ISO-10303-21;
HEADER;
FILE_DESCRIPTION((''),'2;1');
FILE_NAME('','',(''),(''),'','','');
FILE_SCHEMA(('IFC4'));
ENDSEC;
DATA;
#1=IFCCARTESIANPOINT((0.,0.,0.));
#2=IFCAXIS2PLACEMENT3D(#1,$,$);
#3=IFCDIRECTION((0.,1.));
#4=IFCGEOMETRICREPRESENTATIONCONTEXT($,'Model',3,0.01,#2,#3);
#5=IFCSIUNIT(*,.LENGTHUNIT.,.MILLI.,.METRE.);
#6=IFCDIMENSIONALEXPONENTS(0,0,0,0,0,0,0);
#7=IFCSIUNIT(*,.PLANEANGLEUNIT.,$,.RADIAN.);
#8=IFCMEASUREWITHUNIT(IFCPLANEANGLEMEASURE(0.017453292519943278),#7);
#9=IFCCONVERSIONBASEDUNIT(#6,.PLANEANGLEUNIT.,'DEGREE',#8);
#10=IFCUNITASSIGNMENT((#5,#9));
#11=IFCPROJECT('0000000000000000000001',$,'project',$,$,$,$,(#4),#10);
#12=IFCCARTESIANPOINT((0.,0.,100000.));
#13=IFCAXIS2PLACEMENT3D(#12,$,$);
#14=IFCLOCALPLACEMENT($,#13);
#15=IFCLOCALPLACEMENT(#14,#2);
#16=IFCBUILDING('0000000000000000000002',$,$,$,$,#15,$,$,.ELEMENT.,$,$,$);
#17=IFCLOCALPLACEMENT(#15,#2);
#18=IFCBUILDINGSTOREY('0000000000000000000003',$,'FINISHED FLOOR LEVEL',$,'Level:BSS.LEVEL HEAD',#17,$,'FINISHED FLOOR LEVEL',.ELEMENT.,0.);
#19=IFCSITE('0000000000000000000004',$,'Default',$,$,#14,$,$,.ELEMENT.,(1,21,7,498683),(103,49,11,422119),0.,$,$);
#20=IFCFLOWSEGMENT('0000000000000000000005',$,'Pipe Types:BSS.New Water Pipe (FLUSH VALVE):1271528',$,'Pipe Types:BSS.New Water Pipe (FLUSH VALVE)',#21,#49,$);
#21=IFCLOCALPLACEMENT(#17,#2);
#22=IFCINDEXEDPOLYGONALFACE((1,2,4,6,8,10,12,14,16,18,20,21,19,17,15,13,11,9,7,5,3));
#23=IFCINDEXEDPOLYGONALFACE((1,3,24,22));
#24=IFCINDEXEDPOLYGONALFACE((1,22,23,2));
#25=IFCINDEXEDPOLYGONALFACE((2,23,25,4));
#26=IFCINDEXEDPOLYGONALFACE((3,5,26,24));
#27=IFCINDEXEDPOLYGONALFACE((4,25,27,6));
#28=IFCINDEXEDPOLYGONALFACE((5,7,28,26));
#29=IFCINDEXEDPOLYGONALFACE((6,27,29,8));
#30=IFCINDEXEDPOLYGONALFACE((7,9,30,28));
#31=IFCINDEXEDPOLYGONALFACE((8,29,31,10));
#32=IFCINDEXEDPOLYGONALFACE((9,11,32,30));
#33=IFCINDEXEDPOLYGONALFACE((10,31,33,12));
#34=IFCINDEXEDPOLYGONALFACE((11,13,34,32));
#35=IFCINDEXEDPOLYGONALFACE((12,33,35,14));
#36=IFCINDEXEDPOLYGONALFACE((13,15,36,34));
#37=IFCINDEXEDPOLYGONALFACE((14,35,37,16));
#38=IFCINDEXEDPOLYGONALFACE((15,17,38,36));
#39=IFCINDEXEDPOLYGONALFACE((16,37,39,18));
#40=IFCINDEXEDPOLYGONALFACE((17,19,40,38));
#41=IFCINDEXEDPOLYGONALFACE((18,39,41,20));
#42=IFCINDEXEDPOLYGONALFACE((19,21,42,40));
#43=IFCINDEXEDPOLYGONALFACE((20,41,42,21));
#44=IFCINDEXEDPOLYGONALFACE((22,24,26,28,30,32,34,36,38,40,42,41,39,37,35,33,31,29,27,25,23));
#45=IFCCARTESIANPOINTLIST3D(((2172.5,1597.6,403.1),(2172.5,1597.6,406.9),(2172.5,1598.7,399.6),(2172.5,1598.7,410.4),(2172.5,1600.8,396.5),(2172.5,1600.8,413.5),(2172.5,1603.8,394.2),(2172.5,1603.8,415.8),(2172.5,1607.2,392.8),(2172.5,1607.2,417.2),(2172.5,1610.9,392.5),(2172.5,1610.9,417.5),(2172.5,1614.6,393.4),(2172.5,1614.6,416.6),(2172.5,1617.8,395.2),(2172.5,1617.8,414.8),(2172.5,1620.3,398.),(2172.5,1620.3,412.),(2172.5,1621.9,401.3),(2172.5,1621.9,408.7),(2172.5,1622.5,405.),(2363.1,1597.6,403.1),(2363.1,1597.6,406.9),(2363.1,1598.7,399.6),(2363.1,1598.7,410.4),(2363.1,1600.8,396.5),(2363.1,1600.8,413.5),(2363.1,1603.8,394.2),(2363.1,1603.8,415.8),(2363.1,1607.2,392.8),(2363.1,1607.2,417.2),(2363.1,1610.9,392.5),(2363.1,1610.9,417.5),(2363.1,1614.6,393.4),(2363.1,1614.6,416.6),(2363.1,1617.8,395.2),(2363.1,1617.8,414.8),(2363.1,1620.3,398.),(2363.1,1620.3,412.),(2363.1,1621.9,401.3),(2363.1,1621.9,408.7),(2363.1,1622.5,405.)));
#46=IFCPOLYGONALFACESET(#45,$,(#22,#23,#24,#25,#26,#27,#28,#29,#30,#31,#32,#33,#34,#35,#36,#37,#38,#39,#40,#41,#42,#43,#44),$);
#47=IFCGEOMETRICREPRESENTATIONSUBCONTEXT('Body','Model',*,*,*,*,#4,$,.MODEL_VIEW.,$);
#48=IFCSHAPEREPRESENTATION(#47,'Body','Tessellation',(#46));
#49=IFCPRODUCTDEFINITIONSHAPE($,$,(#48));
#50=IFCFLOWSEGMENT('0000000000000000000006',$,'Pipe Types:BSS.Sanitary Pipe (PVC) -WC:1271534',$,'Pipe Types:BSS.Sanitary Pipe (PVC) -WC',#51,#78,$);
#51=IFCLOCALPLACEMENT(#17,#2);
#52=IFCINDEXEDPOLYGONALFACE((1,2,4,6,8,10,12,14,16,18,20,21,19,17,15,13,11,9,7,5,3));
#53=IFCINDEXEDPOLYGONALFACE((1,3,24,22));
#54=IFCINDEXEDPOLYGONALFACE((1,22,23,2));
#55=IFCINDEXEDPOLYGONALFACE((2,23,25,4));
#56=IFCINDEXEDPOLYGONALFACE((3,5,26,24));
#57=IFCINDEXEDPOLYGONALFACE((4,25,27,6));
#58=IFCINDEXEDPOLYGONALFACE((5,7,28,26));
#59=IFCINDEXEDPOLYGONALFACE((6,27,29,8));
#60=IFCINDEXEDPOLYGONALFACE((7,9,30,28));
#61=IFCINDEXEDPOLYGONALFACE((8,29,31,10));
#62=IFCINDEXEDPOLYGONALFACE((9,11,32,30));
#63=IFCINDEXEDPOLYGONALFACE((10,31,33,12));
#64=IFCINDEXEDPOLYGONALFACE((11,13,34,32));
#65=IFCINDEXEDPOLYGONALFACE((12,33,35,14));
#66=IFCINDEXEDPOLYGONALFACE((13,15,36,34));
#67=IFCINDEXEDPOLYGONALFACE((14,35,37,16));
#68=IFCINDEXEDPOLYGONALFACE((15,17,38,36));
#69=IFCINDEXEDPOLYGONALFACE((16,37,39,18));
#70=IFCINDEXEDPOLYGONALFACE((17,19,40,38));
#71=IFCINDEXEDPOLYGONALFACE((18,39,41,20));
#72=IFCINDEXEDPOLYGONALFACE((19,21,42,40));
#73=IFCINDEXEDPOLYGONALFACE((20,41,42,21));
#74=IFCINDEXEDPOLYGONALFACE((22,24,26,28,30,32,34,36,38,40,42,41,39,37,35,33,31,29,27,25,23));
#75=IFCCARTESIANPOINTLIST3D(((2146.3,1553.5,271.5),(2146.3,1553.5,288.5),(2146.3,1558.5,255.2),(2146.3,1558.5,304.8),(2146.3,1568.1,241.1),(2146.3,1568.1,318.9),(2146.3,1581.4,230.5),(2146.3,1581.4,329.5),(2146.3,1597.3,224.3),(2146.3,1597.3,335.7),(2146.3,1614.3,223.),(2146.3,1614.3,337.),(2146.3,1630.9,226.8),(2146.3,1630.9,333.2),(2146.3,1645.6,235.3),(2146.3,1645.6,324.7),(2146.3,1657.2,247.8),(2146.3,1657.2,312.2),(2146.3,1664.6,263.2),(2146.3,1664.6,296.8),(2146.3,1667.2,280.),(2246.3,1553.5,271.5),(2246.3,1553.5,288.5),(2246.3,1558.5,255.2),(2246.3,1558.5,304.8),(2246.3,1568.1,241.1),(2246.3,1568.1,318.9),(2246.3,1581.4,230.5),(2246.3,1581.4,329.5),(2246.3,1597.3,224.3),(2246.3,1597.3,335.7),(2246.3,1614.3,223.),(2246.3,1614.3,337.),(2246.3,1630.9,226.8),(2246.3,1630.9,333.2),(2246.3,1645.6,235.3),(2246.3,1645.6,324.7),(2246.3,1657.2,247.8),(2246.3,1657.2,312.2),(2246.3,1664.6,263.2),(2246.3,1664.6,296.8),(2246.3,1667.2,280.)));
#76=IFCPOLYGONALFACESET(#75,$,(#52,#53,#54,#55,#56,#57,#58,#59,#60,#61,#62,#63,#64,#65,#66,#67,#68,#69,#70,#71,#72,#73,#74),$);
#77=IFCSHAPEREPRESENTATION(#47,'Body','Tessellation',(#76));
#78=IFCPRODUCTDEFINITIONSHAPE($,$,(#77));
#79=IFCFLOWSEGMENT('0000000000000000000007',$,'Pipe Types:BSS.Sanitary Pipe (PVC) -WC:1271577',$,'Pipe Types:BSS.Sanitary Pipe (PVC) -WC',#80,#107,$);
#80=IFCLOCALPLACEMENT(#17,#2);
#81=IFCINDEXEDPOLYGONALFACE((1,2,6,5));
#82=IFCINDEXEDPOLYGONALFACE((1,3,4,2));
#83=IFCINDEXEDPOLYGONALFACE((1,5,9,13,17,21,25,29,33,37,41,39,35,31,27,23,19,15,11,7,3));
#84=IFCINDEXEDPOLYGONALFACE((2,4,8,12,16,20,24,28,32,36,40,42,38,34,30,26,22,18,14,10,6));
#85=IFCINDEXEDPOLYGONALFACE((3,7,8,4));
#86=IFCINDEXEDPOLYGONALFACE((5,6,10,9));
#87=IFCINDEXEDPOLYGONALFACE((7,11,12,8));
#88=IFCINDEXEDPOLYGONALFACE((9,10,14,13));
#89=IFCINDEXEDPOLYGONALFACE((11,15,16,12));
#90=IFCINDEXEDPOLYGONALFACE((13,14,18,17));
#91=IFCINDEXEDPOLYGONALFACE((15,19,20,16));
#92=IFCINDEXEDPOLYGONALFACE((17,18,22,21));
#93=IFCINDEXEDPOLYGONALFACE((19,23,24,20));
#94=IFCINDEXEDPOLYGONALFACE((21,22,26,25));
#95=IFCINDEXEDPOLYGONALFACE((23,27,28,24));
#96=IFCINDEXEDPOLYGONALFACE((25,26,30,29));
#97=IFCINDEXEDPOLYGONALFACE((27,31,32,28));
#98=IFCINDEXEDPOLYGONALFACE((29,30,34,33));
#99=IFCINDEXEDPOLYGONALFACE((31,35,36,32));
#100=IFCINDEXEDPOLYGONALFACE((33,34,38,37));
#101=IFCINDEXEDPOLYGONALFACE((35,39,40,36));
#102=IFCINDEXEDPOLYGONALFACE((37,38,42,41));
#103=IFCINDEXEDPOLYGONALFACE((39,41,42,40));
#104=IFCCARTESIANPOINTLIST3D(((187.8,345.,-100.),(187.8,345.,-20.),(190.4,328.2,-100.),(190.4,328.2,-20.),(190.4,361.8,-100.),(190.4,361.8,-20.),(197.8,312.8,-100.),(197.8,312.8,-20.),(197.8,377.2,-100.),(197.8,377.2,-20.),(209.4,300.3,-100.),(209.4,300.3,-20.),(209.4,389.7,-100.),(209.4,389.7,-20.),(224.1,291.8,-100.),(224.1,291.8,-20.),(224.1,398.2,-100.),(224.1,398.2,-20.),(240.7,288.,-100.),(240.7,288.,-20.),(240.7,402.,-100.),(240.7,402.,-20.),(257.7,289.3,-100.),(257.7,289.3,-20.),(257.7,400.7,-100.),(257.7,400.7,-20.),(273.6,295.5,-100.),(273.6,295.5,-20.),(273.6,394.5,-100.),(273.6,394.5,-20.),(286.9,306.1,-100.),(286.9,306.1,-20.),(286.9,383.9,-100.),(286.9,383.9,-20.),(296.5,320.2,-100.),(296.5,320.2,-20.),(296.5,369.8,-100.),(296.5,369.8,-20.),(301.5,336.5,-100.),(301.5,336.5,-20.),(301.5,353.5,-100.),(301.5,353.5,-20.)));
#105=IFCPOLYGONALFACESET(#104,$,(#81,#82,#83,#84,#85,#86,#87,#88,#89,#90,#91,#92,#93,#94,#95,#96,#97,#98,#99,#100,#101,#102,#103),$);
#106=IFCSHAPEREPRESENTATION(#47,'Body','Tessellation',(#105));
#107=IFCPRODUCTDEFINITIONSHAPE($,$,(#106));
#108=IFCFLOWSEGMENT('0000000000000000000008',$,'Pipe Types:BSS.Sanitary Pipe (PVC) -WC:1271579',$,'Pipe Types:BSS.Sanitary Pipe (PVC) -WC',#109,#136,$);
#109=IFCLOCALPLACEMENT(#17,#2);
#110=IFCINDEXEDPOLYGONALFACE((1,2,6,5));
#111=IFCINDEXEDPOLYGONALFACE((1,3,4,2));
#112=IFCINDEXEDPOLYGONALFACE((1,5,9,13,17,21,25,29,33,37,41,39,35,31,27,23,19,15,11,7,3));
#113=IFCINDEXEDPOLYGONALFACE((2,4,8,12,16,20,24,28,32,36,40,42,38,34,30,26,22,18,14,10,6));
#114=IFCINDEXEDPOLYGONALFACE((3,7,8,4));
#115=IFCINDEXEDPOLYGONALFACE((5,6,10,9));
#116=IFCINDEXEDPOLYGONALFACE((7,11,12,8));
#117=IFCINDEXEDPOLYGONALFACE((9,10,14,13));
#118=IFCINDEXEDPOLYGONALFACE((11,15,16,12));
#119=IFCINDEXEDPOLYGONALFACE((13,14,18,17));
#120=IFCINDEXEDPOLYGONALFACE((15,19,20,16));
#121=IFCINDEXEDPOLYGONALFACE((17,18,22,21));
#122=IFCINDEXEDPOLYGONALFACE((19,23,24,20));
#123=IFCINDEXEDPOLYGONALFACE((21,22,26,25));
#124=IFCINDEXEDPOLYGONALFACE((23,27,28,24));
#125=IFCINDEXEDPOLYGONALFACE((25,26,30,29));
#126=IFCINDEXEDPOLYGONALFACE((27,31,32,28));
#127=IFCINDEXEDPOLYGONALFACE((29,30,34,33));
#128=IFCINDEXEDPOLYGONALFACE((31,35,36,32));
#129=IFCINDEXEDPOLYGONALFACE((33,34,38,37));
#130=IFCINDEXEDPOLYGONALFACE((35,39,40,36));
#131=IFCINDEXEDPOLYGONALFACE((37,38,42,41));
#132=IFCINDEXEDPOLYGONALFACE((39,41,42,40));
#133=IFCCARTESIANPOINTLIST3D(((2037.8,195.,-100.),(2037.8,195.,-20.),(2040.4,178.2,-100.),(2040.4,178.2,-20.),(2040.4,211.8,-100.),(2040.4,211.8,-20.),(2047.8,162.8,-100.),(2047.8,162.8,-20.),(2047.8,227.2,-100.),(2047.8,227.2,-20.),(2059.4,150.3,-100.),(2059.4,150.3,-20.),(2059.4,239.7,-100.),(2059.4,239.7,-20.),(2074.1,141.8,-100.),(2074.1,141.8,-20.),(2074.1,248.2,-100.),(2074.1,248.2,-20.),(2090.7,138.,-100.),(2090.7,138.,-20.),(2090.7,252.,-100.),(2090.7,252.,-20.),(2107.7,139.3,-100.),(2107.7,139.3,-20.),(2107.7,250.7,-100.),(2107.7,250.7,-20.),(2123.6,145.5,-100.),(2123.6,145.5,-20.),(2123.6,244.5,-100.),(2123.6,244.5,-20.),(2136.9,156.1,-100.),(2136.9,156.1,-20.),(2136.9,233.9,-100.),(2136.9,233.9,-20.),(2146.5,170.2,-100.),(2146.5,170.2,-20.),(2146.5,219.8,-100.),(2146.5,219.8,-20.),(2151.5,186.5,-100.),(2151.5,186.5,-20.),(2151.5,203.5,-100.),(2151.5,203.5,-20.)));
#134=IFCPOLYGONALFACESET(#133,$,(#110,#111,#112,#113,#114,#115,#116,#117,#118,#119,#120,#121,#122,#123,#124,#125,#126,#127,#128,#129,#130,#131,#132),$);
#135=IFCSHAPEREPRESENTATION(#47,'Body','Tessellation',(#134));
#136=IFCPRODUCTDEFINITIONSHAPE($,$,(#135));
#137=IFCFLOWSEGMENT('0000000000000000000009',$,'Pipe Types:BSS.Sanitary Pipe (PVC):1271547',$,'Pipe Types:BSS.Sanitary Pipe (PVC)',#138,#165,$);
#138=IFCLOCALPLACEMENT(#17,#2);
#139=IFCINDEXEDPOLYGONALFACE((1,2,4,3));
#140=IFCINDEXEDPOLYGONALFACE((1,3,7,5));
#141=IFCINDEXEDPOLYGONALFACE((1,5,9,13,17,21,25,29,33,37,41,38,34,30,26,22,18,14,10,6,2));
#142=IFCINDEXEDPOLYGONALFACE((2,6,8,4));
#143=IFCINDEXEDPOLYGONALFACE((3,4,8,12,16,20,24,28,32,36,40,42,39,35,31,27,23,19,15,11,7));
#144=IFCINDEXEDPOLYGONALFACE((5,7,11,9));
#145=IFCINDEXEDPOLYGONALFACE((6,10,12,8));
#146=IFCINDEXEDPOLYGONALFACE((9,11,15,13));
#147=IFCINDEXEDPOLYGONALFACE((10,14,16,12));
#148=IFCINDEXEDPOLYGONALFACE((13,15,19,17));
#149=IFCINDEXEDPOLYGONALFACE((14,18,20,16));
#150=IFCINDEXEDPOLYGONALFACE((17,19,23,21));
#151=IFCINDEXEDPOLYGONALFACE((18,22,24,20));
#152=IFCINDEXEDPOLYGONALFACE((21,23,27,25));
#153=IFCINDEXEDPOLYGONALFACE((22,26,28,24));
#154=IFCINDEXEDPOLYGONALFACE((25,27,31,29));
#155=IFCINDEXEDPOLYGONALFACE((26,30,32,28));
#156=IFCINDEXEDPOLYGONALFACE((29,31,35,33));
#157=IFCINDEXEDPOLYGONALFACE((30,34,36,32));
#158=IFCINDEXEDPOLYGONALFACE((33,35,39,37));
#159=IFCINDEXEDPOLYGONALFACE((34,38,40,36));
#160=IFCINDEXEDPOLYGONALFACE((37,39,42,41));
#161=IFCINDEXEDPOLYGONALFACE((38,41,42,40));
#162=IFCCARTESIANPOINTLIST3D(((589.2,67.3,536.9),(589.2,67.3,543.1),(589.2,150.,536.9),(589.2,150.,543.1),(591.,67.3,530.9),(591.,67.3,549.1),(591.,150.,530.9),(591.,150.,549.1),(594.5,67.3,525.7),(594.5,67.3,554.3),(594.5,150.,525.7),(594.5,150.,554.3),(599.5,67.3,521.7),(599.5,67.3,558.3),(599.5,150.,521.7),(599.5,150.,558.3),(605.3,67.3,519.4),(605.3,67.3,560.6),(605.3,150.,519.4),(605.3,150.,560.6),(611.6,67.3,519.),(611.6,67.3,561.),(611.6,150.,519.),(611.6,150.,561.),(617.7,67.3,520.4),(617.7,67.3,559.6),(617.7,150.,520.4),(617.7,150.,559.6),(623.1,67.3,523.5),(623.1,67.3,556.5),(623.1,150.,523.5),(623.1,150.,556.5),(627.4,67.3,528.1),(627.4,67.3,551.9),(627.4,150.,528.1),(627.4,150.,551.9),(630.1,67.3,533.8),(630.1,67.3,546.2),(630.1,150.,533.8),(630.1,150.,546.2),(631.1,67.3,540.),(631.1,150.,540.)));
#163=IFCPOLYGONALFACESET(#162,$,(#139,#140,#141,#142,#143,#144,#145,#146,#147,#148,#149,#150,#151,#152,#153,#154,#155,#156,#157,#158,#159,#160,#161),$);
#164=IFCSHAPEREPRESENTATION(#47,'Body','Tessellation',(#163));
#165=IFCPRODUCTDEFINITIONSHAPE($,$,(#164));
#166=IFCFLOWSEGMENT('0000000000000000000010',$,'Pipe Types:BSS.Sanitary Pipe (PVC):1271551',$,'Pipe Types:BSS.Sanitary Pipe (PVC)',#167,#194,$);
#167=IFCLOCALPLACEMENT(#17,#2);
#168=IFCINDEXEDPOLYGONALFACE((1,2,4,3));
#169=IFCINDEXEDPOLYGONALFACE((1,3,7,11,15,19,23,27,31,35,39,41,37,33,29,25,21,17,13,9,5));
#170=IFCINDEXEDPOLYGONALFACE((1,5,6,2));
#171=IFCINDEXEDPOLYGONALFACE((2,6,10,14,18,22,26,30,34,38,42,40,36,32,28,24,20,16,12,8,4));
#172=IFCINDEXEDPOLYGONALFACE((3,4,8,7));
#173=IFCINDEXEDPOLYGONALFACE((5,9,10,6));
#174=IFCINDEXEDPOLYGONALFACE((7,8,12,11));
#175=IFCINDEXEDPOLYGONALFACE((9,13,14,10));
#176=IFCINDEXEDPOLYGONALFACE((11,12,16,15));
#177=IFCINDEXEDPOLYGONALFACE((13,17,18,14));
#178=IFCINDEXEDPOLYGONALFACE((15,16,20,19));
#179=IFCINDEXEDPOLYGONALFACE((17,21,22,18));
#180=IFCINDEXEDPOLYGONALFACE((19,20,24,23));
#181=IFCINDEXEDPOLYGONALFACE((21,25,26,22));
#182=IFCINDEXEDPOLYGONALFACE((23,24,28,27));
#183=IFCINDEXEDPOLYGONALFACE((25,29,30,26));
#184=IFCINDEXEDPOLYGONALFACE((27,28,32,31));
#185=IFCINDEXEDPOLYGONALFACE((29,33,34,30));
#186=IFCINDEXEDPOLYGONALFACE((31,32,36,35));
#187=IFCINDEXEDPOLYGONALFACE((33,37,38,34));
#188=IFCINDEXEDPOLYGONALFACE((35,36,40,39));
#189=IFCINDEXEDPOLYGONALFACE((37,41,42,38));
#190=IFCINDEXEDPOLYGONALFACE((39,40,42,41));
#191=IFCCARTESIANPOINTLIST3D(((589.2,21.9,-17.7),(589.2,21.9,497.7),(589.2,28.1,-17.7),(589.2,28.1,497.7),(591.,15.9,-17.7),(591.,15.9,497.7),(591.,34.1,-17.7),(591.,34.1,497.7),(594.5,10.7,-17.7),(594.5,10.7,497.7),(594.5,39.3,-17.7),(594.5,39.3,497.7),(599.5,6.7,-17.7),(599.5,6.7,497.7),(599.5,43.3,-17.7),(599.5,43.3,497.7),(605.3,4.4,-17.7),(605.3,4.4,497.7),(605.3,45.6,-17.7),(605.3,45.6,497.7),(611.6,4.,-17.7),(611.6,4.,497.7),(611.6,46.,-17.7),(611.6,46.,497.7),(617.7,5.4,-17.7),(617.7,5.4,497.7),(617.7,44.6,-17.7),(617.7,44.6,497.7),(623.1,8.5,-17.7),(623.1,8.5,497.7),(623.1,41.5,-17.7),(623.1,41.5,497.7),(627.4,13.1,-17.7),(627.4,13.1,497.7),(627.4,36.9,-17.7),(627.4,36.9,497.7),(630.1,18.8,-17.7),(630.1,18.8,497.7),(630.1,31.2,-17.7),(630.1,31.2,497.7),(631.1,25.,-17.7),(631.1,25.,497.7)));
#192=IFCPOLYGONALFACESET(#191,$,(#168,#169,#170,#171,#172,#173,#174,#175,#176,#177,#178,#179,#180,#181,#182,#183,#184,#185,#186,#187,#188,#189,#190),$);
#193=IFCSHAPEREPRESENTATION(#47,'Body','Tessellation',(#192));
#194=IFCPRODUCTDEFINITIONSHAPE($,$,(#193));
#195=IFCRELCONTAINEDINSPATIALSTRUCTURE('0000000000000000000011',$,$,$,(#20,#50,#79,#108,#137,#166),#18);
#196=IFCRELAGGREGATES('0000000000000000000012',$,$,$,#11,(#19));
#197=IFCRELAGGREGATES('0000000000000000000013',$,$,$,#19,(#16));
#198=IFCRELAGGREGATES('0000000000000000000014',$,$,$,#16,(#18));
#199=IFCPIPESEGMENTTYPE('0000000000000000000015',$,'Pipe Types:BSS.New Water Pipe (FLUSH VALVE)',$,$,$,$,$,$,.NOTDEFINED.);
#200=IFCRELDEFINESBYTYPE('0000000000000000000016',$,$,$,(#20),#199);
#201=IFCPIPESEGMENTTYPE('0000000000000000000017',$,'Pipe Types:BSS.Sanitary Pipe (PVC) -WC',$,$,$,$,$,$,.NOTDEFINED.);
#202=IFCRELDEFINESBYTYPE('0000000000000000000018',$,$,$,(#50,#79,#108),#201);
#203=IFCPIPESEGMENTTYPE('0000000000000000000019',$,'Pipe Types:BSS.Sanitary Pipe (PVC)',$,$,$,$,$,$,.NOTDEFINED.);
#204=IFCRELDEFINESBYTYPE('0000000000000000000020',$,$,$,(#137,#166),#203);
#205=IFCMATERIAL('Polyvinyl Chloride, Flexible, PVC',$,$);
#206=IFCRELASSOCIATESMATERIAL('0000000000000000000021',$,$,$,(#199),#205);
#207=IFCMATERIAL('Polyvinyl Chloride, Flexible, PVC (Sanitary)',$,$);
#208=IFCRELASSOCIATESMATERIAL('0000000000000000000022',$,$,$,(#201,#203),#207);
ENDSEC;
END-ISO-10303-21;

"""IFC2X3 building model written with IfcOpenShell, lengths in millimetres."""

from ifc_helpers import new_model, entity, si_unit, converted_unit, direction, frame, frame_2d, origin, origin_2d_with_axis, place, context, subcontext, project, spatial, circle, extrude, material, type_object, element, save


model = new_model("IFC2X3")

# Units and contexts
model_context = context("Model", 3, precision=0.01, world=origin(), true_north=direction((0.0, 1.0)))
body_context = subcontext(model_context, "Body", "Model", "MODEL_VIEW")
ifc_project = project(units=[si_unit("LENGTHUNIT", "METRE", prefix="MILLI"), converted_unit("PLANEANGLEUNIT", "DEGREE", entity("IfcPlaneAngleMeasure", 0.017453292519943278), si_unit("PLANEANGLEUNIT", "RADIAN"), dimensions=[0, 0, 0, 0, 0, 0, 0])], contexts=[model_context])

# Site, building, storey
site_placement = place(None, frame((0.0, 0.0, 100000.0)))
site = spatial("IfcSite", under=ifc_project, at=site_placement, Name="Default", CompositionType="ELEMENT", RefLatitude=(1, 21, 7, 498683), RefLongitude=(103, 49, 11, 422119), RefElevation=0.0)
building_placement = place(site_placement, origin())
building = spatial("IfcBuilding", under=site, at=building_placement, CompositionType="ELEMENT")
storey_placement = place(building_placement, origin())
storey = spatial("IfcBuildingStorey", under=building, at=storey_placement, Name="FINISHED FLOOR LEVEL", ObjectType="Level:BSS.LEVEL HEAD", LongName="FINISHED FLOOR LEVEL", CompositionType="ELEMENT", Elevation=0.0)

# Flow segments
ifc_material_1 = material(Name="Polyvinyl Chloride, Flexible, PVC")
pipe_segment_type_1 = type_object("IfcPipeSegmentType", Name="Pipe Types:BSS.New Water Pipe (FLUSH VALVE)", PredefinedType="NOTDEFINED", material=ifc_material_1)
flow_segment_1_placement = place(storey_placement, origin())
element("IfcFlowSegment", 1, at=flow_segment_1_placement, inside=storey, type_object=pipe_segment_type_1, Name="Pipe Types:BSS.New Water Pipe (FLUSH VALVE):1271528", ObjectType="Pipe Types:BSS.New Water Pipe (FLUSH VALVE)", context=body_context, shape_type="SweptSolid", body=[
    extrude(circle(Radius=12.5, at=origin_2d_with_axis()), frame((2172.5, 1610.0, 405.0), z_axis=(1.0, 0.0, 0.0), x_axis=(0.0, 1.0, 0.0)), (0.0, 0.0, 1.0), 190.6),
])
ifc_material_2 = material(Name="Polyvinyl Chloride, Flexible, PVC (Sanitary)")
pipe_segment_type_2 = type_object("IfcPipeSegmentType", Name="Pipe Types:BSS.Sanitary Pipe (PVC) -WC", PredefinedType="NOTDEFINED", material=ifc_material_2)
flow_segment_2_placement = place(storey_placement, origin())
element("IfcFlowSegment", 2, at=flow_segment_2_placement, inside=storey, type_object=pipe_segment_type_2, Name="Pipe Types:BSS.Sanitary Pipe (PVC) -WC:1271534", ObjectType="Pipe Types:BSS.Sanitary Pipe (PVC) -WC", context=body_context, shape_type="SweptSolid", body=[
    extrude(circle(Radius=57.2, at=frame_2d((0.0, 0.0), x_axis=(1.0, 0.0))), frame((2146.3, 1610.0, 280.0), z_axis=(1.0, 0.0, 0.0), x_axis=(0.0, 1.0, 0.0)), (0.0, 0.0, 1.0), 100.0),
])
flow_segment_3_placement = place(storey_placement, origin())
element("IfcFlowSegment", 3, at=flow_segment_3_placement, inside=storey, type_object=pipe_segment_type_2, Name="Pipe Types:BSS.Sanitary Pipe (PVC) -WC:1271577", ObjectType="Pipe Types:BSS.Sanitary Pipe (PVC) -WC", context=body_context, shape_type="SweptSolid", body=[
    extrude(circle(Radius=57.2, at=frame_2d((0.0, 0.0), x_axis=(1.0, 0.0))), frame((245.0, 345.0, -100.0), z_axis=(0.0, 0.0, 1.0), x_axis=(-1.0, 0.0, 0.0)), (0.0, 0.0, 1.0), 80.0),
])
flow_segment_4_placement = place(storey_placement, origin())
element("IfcFlowSegment", 4, at=flow_segment_4_placement, inside=storey, type_object=pipe_segment_type_2, Name="Pipe Types:BSS.Sanitary Pipe (PVC) -WC:1271579", ObjectType="Pipe Types:BSS.Sanitary Pipe (PVC) -WC", context=body_context, shape_type="SweptSolid", body=[
    extrude(circle(Radius=57.2, at=frame_2d((0.0, 0.0), x_axis=(1.0, 0.0))), frame((2095.0, 195.0, -100.0), z_axis=(0.0, 0.0, 1.0), x_axis=(-1.0, 0.0, 0.0)), (0.0, 0.0, 1.0), 80.0),
])
pipe_segment_type_3 = type_object("IfcPipeSegmentType", Name="Pipe Types:BSS.Sanitary Pipe (PVC)", PredefinedType="NOTDEFINED", material=ifc_material_2)
flow_segment_5_placement = place(storey_placement, origin())
element("IfcFlowSegment", 5, at=flow_segment_5_placement, inside=storey, type_object=pipe_segment_type_3, Name="Pipe Types:BSS.Sanitary Pipe (PVC):1271547", ObjectType="Pipe Types:BSS.Sanitary Pipe (PVC)", context=body_context, shape_type="SweptSolid", body=[
    extrude(circle(Radius=21.1, at=frame_2d((0.0, 0.0), x_axis=(1.0, 0.0))), frame((610.0, 67.3, 540.0), z_axis=(0.0, 1.0, 0.0), x_axis=(1.0, 0.0, 0.0)), (0.0, 0.0, 1.0), 82.7),
])
flow_segment_6_placement = place(storey_placement, origin())
element("IfcFlowSegment", 6, at=flow_segment_6_placement, inside=storey, type_object=pipe_segment_type_3, Name="Pipe Types:BSS.Sanitary Pipe (PVC):1271551", ObjectType="Pipe Types:BSS.Sanitary Pipe (PVC)", context=body_context, shape_type="SweptSolid", body=[
    extrude(circle(Radius=21.1, at=frame_2d((0.0, 0.0), x_axis=(1.0, 0.0))), frame((610.0, 25.0, -17.7)), (0.0, 0.0, 1.0), 515.4),
])

save(model, "model.ifc")
